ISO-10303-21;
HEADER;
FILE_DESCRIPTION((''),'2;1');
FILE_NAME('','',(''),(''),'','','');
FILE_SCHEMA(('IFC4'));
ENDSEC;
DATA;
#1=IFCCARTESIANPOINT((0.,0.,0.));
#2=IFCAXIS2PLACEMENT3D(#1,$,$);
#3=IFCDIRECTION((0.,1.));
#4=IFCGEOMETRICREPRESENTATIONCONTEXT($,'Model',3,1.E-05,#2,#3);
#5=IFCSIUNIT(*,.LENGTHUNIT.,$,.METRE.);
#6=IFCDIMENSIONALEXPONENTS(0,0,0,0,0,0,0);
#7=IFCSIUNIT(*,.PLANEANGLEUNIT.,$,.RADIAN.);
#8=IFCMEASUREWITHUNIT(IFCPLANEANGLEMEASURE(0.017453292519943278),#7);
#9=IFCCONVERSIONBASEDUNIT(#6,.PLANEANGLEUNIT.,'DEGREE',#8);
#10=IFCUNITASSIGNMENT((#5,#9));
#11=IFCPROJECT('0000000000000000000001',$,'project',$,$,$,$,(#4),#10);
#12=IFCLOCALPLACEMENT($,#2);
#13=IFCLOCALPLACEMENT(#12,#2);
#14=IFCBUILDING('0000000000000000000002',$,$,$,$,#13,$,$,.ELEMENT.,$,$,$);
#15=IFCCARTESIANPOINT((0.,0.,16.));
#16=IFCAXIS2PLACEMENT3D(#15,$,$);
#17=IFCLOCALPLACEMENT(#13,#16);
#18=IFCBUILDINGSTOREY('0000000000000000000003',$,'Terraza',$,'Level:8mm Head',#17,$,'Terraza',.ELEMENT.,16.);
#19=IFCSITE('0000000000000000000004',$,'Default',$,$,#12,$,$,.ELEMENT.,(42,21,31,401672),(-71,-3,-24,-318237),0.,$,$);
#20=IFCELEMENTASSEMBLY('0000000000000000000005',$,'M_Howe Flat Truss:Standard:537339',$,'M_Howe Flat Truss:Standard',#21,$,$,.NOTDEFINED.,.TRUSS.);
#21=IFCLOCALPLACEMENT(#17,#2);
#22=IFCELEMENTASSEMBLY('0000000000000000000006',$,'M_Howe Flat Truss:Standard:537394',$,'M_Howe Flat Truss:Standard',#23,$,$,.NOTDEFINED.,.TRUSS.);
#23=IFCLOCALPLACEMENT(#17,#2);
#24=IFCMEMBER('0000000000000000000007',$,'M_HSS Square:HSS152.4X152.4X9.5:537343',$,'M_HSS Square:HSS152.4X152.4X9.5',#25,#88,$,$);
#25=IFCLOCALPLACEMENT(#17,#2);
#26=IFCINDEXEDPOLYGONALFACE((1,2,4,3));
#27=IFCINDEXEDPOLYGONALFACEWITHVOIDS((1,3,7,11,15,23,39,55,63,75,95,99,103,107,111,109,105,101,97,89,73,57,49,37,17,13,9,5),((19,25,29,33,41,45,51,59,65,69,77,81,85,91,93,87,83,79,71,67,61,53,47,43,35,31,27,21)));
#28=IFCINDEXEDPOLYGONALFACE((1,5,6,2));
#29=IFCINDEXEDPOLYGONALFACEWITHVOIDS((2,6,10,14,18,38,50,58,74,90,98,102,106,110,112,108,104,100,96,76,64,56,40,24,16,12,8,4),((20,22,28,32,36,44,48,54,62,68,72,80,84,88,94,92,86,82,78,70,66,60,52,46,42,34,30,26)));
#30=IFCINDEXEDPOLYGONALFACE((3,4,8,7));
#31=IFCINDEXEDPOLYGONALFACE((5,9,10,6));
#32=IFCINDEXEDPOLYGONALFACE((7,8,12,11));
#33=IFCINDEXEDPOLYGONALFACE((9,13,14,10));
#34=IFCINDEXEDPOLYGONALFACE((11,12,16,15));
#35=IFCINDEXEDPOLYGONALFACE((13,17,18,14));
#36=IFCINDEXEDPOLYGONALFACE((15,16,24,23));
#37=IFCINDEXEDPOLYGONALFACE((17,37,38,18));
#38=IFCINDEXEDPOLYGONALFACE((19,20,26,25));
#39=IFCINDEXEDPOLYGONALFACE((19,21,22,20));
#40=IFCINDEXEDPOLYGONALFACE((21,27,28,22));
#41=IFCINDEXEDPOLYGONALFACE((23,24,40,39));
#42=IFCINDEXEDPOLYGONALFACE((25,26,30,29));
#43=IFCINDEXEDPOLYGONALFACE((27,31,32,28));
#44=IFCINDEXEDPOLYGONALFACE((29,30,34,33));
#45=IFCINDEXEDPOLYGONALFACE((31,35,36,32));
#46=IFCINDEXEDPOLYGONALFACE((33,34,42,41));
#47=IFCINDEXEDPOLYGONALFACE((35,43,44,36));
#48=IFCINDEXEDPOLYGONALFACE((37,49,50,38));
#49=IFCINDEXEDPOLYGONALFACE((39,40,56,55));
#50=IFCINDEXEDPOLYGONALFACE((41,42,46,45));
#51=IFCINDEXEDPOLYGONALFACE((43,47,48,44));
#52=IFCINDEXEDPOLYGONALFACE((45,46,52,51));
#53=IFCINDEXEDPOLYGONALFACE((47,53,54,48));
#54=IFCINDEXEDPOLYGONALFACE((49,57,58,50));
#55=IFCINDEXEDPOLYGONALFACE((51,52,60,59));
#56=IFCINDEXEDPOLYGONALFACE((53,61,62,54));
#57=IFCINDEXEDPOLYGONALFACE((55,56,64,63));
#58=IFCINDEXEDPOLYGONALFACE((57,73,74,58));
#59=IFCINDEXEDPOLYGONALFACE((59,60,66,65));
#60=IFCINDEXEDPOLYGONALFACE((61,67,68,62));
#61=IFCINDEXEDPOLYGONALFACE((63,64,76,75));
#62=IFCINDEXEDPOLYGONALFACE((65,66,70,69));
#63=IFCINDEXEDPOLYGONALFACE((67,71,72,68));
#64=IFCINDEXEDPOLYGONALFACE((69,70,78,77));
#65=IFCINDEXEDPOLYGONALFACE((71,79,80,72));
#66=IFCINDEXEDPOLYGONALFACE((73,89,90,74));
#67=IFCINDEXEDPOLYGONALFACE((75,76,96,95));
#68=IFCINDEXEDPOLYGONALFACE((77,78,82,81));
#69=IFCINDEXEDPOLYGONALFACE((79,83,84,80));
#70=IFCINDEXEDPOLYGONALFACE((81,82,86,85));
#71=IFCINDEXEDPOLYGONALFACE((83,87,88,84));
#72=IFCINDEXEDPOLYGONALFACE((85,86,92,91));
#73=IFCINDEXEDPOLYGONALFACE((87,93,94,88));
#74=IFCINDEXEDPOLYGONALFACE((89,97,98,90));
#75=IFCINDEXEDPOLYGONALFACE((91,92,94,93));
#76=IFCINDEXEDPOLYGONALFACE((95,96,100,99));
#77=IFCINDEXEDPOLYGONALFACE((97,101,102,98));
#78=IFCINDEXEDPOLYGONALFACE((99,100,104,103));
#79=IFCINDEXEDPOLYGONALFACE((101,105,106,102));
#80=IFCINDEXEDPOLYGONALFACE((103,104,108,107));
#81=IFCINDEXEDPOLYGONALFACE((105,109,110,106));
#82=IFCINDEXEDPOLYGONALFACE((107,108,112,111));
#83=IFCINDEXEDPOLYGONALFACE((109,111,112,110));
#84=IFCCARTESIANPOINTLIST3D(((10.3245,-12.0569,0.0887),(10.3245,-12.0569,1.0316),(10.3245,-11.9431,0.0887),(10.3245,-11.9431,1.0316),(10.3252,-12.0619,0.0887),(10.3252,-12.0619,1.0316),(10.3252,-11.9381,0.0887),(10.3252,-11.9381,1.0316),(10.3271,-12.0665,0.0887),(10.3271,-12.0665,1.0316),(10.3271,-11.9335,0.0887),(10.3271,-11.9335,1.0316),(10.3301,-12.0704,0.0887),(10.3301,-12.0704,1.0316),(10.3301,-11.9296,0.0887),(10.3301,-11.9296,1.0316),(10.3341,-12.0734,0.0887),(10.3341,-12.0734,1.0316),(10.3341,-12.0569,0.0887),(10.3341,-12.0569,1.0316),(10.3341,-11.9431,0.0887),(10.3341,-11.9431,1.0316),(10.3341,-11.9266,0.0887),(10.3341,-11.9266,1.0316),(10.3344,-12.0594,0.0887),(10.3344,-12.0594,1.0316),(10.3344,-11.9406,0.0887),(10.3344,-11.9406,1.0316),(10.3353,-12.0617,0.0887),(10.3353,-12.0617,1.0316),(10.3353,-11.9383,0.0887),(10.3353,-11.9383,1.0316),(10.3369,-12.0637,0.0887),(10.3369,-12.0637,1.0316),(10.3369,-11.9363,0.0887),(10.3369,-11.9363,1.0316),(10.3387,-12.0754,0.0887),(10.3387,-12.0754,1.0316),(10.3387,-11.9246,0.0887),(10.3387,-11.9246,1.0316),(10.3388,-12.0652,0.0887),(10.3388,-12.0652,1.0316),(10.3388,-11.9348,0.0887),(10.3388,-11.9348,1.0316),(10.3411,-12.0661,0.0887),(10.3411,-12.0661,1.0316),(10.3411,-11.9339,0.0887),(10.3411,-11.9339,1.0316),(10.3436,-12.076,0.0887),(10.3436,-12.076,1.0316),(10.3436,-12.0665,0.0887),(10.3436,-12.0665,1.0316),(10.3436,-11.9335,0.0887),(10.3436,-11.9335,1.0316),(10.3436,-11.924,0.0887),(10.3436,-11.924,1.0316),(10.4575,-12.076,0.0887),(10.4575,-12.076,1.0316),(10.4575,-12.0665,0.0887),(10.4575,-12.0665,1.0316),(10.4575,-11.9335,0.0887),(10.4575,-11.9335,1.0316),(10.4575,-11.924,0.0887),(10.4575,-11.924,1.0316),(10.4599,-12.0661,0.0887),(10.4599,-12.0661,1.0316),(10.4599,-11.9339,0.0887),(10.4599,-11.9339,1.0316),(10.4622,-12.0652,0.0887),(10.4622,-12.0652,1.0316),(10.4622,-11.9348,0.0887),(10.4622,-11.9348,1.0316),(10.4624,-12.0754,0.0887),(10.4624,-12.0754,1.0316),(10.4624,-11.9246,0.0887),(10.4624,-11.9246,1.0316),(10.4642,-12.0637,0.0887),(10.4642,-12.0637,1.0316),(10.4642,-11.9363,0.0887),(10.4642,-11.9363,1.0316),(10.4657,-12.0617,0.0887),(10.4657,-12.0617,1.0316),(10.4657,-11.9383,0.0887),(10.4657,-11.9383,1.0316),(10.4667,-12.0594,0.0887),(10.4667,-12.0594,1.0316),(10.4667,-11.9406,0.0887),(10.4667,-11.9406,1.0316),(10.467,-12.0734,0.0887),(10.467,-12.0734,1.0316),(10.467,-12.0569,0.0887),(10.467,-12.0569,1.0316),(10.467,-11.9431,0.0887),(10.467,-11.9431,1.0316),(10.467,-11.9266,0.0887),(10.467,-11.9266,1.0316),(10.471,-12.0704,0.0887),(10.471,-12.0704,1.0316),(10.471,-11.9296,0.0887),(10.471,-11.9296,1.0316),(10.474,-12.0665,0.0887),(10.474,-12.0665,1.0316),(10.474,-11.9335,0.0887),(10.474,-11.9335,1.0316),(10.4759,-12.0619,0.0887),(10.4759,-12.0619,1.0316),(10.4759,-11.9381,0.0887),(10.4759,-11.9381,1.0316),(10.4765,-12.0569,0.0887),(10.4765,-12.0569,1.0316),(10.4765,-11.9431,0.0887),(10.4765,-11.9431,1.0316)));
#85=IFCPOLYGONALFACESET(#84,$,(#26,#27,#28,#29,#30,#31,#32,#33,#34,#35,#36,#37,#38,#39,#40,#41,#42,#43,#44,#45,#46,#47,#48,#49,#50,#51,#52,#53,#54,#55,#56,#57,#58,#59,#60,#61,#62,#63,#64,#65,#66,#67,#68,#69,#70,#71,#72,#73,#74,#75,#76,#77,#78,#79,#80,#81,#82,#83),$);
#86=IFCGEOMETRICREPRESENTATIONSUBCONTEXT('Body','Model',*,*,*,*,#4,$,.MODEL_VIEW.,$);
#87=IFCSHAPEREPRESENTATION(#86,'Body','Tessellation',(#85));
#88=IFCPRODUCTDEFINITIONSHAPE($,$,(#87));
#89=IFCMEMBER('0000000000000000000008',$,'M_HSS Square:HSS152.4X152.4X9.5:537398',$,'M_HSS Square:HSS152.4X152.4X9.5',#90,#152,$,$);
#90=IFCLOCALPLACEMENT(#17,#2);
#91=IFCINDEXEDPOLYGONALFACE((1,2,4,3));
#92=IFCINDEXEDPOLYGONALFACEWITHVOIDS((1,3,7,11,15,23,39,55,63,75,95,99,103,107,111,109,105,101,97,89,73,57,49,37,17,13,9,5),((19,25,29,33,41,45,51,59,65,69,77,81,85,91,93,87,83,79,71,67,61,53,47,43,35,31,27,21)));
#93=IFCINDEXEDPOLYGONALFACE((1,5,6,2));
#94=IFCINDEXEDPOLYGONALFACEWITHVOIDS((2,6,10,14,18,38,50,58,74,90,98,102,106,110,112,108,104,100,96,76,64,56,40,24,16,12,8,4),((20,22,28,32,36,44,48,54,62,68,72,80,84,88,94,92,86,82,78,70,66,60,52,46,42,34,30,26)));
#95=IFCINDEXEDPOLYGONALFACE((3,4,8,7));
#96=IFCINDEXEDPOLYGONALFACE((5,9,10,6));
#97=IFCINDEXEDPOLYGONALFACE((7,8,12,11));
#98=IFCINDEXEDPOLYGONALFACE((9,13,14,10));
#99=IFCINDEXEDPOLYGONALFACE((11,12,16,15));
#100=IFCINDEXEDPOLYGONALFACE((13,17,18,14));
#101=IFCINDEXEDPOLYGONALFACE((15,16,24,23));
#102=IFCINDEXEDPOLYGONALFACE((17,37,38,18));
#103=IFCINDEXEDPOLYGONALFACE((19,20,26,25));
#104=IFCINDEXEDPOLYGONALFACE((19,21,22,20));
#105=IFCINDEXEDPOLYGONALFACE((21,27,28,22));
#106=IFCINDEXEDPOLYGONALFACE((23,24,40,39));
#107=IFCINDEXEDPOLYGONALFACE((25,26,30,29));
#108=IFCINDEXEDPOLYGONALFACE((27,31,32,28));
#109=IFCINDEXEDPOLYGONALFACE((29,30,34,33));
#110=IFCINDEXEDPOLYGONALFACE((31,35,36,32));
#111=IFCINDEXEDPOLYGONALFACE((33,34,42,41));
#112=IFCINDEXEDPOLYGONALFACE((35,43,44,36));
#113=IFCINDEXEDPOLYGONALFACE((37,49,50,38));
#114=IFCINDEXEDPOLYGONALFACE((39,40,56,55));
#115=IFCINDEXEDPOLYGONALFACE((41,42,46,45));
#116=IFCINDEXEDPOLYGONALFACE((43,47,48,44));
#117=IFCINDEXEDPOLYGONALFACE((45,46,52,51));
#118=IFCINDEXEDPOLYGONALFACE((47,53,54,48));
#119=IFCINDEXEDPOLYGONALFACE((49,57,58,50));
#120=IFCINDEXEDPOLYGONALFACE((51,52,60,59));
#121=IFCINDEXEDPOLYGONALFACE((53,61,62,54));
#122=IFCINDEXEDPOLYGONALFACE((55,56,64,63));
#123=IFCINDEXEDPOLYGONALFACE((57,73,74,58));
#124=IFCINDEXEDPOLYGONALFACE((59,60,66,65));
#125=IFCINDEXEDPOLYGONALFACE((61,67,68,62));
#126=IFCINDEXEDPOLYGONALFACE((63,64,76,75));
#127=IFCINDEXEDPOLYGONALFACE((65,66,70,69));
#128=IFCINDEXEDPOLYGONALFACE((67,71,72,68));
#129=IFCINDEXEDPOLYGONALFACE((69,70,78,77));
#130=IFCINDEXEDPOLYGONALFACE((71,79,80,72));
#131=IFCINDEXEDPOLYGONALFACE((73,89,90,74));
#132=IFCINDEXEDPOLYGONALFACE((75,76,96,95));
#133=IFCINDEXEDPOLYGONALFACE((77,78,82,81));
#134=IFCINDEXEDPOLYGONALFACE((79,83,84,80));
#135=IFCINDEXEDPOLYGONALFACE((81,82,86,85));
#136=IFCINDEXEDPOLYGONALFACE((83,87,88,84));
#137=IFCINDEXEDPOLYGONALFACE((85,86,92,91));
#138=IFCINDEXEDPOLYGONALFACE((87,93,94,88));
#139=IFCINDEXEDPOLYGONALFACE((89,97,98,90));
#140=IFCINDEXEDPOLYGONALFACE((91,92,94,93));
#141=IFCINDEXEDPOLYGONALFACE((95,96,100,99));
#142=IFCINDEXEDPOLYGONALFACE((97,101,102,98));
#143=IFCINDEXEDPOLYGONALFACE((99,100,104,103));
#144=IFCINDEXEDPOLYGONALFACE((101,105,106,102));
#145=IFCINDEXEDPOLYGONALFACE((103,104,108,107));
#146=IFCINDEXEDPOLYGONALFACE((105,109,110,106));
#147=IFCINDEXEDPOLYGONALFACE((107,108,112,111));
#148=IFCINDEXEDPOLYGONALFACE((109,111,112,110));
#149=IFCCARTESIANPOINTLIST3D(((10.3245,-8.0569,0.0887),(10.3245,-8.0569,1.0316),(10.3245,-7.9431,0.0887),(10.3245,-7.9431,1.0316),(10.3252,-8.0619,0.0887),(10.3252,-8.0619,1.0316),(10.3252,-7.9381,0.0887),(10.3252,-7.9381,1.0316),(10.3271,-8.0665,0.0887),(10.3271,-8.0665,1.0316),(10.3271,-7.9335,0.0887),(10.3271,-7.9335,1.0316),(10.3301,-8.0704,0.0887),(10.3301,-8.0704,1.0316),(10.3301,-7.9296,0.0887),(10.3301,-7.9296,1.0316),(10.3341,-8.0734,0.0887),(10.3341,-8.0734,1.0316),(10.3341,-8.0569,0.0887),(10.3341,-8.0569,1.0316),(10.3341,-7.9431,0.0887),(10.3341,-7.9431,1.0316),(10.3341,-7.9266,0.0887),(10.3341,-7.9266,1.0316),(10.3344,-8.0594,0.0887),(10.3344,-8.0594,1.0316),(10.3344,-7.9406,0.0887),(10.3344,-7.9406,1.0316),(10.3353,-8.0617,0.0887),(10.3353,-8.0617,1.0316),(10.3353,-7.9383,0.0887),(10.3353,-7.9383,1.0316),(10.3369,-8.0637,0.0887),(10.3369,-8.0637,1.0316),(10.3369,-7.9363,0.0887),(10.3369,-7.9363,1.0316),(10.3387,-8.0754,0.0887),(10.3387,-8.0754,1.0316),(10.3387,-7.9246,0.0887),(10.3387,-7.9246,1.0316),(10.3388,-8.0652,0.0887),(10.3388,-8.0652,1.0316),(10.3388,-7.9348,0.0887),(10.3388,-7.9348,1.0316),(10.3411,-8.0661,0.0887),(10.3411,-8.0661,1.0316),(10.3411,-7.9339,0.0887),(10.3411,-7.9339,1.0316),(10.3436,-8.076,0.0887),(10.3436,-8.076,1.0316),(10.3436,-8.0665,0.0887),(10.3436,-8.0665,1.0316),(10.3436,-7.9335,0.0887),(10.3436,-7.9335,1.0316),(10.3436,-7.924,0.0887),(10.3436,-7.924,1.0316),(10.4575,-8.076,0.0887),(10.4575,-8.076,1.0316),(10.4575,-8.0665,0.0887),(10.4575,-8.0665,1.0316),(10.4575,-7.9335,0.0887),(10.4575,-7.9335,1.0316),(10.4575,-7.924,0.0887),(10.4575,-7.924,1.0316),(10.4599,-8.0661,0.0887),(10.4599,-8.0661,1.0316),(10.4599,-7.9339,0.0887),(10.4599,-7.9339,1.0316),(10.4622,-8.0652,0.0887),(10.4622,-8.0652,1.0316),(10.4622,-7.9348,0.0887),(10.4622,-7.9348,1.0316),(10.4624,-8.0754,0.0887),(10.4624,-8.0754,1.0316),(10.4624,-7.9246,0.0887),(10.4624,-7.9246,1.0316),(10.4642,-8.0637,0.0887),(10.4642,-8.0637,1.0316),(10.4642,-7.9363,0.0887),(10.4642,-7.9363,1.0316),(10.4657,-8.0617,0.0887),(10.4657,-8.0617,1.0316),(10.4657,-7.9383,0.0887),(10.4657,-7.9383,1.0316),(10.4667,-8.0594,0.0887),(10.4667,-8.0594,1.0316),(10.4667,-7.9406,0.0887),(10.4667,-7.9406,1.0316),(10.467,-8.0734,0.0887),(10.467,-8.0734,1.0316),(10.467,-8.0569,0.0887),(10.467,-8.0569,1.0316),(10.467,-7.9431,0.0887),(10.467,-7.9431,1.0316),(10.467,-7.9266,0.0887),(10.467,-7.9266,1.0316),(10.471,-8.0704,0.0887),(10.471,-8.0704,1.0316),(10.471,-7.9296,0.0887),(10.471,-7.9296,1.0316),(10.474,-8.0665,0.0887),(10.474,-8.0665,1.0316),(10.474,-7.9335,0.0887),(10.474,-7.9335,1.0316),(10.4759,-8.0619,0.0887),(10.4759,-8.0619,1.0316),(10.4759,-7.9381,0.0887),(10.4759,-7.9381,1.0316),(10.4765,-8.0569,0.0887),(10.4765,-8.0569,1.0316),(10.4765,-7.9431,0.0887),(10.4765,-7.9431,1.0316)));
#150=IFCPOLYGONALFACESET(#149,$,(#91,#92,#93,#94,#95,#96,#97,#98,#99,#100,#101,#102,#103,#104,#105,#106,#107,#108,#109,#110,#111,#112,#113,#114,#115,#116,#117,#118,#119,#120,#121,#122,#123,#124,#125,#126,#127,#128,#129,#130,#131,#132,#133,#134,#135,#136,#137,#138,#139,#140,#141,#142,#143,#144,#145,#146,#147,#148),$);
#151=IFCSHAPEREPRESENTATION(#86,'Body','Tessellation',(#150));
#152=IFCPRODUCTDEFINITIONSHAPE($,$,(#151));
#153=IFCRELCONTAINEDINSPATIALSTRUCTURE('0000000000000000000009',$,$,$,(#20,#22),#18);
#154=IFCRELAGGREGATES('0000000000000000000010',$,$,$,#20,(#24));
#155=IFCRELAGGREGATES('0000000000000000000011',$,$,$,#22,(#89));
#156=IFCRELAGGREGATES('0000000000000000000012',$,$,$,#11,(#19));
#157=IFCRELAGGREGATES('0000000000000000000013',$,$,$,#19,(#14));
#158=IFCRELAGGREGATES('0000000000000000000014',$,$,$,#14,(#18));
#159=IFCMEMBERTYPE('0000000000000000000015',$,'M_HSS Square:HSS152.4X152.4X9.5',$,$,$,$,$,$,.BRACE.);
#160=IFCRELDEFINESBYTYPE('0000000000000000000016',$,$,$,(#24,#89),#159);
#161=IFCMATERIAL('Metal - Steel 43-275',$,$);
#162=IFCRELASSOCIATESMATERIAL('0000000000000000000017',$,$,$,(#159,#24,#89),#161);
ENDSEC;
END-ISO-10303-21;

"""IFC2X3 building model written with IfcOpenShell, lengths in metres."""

from ifc_helpers import new_model, entity, si_unit, converted_unit, direction, frame, frame_2d, origin, place, context, subcontext, project, spatial, polyline, circle_curve, parameter, trimmed, segment, composite_curve, outline, extrude, source, transform, mapped, material, type_object, type_shapes, element, aggregate, save


model = new_model("IFC2X3")

# Units and contexts
model_context = context("Model", 3, precision=1e-05, world=origin(), true_north=direction((0.0, 1.0)))
body_context = subcontext(model_context, "Body", "Model", "MODEL_VIEW")
ifc_project = project(units=[si_unit("LENGTHUNIT", "METRE"), converted_unit("PLANEANGLEUNIT", "DEGREE", entity("IfcPlaneAngleMeasure", 0.017453292519943278), si_unit("PLANEANGLEUNIT", "RADIAN"), dimensions=[0, 0, 0, 0, 0, 0, 0])], contexts=[model_context])

# Site, building, storey
site_placement = place(None, origin())
site = spatial("IfcSite", under=ifc_project, at=site_placement, Name="Default", CompositionType="ELEMENT", RefLatitude=(42, 21, 31, 401672), RefLongitude=(-71, -3, -24, -318237), RefElevation=0.0)
building_placement = place(site_placement, origin())
building = spatial("IfcBuilding", under=site, at=building_placement, CompositionType="ELEMENT")
storey_placement = place(building_placement, frame((0.0, 0.0, 16.0)))
storey = spatial("IfcBuildingStorey", under=building, at=storey_placement, Name="Terraza", ObjectType="Level:8mm Head", LongName="Terraza", CompositionType="ELEMENT", Elevation=16.0)

# Element assemblies
ifc_material = material(Name="Metal - Steel 43-275")
assembly_1_placement = place(storey_placement, origin())
assembly_1 = element("IfcElementAssembly", 1, at=assembly_1_placement, inside=storey, Name="M_Howe Flat Truss:Standard:537339", ObjectType="M_Howe Flat Truss:Standard", AssemblyPlace="NOTDEFINED", PredefinedType="TRUSS")
assembly_2_placement = place(storey_placement, origin())
assembly_2 = element("IfcElementAssembly", 2, at=assembly_2_placement, inside=storey, Name="M_Howe Flat Truss:Standard:537394", ObjectType="M_Howe Flat Truss:Standard", AssemblyPlace="NOTDEFINED", PredefinedType="TRUSS")

# Members
member_type_1 = type_object("IfcMemberType", Name="M_HSS Square:HSS152.4X152.4X9.5", PredefinedType="BRACE", material=ifc_material)
shared_shape_1 = source(origin(), body_context, "Body", "SweptSolid", [
    extrude(outline(composite_curve([segment(polyline([(-0.0569, -0.076), (0.0569, -0.076)]), True, "CONTINUOUS"), segment(trimmed(circle_curve(frame_2d((0.0569, -0.0569), x_axis=(0.0, 1.0)), 0.0191), [parameter(180.0)], [parameter(270.0)], True, "PARAMETER"), True, "CONTINUOUS"), segment(polyline([(0.076, -0.0569), (0.076, 0.0569)]), True, "CONTINUOUS"), segment(trimmed(circle_curve(frame_2d((0.0569, 0.0569), x_axis=(0.0, 1.0)), 0.0191), [parameter(270.0)], [parameter(0.0)], True, "PARAMETER"), True, "CONTINUOUS"), segment(polyline([(0.0569, 0.076), (-0.0569, 0.076)]), True, "CONTINUOUS"), segment(trimmed(circle_curve(frame_2d((-0.0569, 0.0569), x_axis=(0.0, 1.0)), 0.0191), [parameter(0.0)], [parameter(90.0)], True, "PARAMETER"), True, "CONTINUOUS"), segment(polyline([(-0.076, 0.0569), (-0.076, -0.0569)]), True, "CONTINUOUS"), segment(trimmed(circle_curve(frame_2d((-0.0569, -0.0569), x_axis=(0.0, 1.0)), 0.0191), [parameter(90.0)], [parameter(180.0)], True, "PARAMETER"), True, "CONTINUOUS")], self_intersect=False), holes=[composite_curve([segment(trimmed(circle_curve(frame_2d((-0.0569, 0.0569), x_axis=(0.0, 1.0)), 0.0095), [parameter(360.0)], [parameter(90.0)], True, "PARAMETER"), False, "CONTINUOUS"), segment(polyline([(-0.0569, 0.0665), (0.0569, 0.0665)]), True, "CONTINUOUS"), segment(trimmed(circle_curve(frame_2d((0.0569, 0.0569), x_axis=(0.0, 1.0)), 0.0095), [parameter(270.0)], [parameter(360.0)], True, "PARAMETER"), False, "CONTINUOUS"), segment(polyline([(0.0665, 0.0569), (0.0665, -0.0569)]), True, "CONTINUOUS"), segment(trimmed(circle_curve(frame_2d((0.0569, -0.0569), x_axis=(0.0, 1.0)), 0.0095), [parameter(180.0)], [parameter(270.0)], True, "PARAMETER"), False, "CONTINUOUS"), segment(polyline([(0.0569, -0.0665), (-0.0569, -0.0665)]), True, "CONTINUOUS"), segment(trimmed(circle_curve(frame_2d((-0.0569, -0.0569), x_axis=(0.0, 1.0)), 0.0095), [parameter(90.0)], [parameter(180.0)], True, "PARAMETER"), False, "CONTINUOUS"), segment(polyline([(-0.0665, -0.0569), (-0.0665, 0.0569)]), True, "CONTINUOUS")], self_intersect=False)]), frame((-0.4738, 0.0, 0.0), z_axis=(1.0, 0.0, 0.0), x_axis=(0.0, 0.0, -1.0)), (0.0, 0.0, 1.0), 0.9429),
])
type_shapes(member_type_1, [shared_shape_1])
member_1_placement = place(assembly_1_placement, frame((10.4005, -12.0, 0.5625), z_axis=(1.0, 0.0, 0.0), x_axis=(0.0, 0.0, 1.0)))
member_1 = element("IfcMember", 3, at=member_1_placement, type_object=member_type_1, material=ifc_material, Name="M_HSS Square:HSS152.4X152.4X9.5:537343", ObjectType="M_HSS Square:HSS152.4X152.4X9.5", context=body_context, shape_type="MappedRepresentation", body=[
    mapped(shared_shape_1, transform((0.0, 0.0, 0.0), scale=1.0)),
])
member_2_placement = place(assembly_2_placement, frame((10.4005, -8.0, 0.5625), z_axis=(1.0, 0.0, 0.0), x_axis=(0.0, 0.0, 1.0)))
member_2 = element("IfcMember", 4, at=member_2_placement, type_object=member_type_1, material=ifc_material, Name="M_HSS Square:HSS152.4X152.4X9.5:537398", ObjectType="M_HSS Square:HSS152.4X152.4X9.5", context=body_context, shape_type="MappedRepresentation", body=[
    mapped(shared_shape_1, transform((0.0, 0.0, 0.0), scale=1.0)),
])

aggregate(assembly_1, [member_1])
aggregate(assembly_2, [member_2])

save(model, "model.ifc")
